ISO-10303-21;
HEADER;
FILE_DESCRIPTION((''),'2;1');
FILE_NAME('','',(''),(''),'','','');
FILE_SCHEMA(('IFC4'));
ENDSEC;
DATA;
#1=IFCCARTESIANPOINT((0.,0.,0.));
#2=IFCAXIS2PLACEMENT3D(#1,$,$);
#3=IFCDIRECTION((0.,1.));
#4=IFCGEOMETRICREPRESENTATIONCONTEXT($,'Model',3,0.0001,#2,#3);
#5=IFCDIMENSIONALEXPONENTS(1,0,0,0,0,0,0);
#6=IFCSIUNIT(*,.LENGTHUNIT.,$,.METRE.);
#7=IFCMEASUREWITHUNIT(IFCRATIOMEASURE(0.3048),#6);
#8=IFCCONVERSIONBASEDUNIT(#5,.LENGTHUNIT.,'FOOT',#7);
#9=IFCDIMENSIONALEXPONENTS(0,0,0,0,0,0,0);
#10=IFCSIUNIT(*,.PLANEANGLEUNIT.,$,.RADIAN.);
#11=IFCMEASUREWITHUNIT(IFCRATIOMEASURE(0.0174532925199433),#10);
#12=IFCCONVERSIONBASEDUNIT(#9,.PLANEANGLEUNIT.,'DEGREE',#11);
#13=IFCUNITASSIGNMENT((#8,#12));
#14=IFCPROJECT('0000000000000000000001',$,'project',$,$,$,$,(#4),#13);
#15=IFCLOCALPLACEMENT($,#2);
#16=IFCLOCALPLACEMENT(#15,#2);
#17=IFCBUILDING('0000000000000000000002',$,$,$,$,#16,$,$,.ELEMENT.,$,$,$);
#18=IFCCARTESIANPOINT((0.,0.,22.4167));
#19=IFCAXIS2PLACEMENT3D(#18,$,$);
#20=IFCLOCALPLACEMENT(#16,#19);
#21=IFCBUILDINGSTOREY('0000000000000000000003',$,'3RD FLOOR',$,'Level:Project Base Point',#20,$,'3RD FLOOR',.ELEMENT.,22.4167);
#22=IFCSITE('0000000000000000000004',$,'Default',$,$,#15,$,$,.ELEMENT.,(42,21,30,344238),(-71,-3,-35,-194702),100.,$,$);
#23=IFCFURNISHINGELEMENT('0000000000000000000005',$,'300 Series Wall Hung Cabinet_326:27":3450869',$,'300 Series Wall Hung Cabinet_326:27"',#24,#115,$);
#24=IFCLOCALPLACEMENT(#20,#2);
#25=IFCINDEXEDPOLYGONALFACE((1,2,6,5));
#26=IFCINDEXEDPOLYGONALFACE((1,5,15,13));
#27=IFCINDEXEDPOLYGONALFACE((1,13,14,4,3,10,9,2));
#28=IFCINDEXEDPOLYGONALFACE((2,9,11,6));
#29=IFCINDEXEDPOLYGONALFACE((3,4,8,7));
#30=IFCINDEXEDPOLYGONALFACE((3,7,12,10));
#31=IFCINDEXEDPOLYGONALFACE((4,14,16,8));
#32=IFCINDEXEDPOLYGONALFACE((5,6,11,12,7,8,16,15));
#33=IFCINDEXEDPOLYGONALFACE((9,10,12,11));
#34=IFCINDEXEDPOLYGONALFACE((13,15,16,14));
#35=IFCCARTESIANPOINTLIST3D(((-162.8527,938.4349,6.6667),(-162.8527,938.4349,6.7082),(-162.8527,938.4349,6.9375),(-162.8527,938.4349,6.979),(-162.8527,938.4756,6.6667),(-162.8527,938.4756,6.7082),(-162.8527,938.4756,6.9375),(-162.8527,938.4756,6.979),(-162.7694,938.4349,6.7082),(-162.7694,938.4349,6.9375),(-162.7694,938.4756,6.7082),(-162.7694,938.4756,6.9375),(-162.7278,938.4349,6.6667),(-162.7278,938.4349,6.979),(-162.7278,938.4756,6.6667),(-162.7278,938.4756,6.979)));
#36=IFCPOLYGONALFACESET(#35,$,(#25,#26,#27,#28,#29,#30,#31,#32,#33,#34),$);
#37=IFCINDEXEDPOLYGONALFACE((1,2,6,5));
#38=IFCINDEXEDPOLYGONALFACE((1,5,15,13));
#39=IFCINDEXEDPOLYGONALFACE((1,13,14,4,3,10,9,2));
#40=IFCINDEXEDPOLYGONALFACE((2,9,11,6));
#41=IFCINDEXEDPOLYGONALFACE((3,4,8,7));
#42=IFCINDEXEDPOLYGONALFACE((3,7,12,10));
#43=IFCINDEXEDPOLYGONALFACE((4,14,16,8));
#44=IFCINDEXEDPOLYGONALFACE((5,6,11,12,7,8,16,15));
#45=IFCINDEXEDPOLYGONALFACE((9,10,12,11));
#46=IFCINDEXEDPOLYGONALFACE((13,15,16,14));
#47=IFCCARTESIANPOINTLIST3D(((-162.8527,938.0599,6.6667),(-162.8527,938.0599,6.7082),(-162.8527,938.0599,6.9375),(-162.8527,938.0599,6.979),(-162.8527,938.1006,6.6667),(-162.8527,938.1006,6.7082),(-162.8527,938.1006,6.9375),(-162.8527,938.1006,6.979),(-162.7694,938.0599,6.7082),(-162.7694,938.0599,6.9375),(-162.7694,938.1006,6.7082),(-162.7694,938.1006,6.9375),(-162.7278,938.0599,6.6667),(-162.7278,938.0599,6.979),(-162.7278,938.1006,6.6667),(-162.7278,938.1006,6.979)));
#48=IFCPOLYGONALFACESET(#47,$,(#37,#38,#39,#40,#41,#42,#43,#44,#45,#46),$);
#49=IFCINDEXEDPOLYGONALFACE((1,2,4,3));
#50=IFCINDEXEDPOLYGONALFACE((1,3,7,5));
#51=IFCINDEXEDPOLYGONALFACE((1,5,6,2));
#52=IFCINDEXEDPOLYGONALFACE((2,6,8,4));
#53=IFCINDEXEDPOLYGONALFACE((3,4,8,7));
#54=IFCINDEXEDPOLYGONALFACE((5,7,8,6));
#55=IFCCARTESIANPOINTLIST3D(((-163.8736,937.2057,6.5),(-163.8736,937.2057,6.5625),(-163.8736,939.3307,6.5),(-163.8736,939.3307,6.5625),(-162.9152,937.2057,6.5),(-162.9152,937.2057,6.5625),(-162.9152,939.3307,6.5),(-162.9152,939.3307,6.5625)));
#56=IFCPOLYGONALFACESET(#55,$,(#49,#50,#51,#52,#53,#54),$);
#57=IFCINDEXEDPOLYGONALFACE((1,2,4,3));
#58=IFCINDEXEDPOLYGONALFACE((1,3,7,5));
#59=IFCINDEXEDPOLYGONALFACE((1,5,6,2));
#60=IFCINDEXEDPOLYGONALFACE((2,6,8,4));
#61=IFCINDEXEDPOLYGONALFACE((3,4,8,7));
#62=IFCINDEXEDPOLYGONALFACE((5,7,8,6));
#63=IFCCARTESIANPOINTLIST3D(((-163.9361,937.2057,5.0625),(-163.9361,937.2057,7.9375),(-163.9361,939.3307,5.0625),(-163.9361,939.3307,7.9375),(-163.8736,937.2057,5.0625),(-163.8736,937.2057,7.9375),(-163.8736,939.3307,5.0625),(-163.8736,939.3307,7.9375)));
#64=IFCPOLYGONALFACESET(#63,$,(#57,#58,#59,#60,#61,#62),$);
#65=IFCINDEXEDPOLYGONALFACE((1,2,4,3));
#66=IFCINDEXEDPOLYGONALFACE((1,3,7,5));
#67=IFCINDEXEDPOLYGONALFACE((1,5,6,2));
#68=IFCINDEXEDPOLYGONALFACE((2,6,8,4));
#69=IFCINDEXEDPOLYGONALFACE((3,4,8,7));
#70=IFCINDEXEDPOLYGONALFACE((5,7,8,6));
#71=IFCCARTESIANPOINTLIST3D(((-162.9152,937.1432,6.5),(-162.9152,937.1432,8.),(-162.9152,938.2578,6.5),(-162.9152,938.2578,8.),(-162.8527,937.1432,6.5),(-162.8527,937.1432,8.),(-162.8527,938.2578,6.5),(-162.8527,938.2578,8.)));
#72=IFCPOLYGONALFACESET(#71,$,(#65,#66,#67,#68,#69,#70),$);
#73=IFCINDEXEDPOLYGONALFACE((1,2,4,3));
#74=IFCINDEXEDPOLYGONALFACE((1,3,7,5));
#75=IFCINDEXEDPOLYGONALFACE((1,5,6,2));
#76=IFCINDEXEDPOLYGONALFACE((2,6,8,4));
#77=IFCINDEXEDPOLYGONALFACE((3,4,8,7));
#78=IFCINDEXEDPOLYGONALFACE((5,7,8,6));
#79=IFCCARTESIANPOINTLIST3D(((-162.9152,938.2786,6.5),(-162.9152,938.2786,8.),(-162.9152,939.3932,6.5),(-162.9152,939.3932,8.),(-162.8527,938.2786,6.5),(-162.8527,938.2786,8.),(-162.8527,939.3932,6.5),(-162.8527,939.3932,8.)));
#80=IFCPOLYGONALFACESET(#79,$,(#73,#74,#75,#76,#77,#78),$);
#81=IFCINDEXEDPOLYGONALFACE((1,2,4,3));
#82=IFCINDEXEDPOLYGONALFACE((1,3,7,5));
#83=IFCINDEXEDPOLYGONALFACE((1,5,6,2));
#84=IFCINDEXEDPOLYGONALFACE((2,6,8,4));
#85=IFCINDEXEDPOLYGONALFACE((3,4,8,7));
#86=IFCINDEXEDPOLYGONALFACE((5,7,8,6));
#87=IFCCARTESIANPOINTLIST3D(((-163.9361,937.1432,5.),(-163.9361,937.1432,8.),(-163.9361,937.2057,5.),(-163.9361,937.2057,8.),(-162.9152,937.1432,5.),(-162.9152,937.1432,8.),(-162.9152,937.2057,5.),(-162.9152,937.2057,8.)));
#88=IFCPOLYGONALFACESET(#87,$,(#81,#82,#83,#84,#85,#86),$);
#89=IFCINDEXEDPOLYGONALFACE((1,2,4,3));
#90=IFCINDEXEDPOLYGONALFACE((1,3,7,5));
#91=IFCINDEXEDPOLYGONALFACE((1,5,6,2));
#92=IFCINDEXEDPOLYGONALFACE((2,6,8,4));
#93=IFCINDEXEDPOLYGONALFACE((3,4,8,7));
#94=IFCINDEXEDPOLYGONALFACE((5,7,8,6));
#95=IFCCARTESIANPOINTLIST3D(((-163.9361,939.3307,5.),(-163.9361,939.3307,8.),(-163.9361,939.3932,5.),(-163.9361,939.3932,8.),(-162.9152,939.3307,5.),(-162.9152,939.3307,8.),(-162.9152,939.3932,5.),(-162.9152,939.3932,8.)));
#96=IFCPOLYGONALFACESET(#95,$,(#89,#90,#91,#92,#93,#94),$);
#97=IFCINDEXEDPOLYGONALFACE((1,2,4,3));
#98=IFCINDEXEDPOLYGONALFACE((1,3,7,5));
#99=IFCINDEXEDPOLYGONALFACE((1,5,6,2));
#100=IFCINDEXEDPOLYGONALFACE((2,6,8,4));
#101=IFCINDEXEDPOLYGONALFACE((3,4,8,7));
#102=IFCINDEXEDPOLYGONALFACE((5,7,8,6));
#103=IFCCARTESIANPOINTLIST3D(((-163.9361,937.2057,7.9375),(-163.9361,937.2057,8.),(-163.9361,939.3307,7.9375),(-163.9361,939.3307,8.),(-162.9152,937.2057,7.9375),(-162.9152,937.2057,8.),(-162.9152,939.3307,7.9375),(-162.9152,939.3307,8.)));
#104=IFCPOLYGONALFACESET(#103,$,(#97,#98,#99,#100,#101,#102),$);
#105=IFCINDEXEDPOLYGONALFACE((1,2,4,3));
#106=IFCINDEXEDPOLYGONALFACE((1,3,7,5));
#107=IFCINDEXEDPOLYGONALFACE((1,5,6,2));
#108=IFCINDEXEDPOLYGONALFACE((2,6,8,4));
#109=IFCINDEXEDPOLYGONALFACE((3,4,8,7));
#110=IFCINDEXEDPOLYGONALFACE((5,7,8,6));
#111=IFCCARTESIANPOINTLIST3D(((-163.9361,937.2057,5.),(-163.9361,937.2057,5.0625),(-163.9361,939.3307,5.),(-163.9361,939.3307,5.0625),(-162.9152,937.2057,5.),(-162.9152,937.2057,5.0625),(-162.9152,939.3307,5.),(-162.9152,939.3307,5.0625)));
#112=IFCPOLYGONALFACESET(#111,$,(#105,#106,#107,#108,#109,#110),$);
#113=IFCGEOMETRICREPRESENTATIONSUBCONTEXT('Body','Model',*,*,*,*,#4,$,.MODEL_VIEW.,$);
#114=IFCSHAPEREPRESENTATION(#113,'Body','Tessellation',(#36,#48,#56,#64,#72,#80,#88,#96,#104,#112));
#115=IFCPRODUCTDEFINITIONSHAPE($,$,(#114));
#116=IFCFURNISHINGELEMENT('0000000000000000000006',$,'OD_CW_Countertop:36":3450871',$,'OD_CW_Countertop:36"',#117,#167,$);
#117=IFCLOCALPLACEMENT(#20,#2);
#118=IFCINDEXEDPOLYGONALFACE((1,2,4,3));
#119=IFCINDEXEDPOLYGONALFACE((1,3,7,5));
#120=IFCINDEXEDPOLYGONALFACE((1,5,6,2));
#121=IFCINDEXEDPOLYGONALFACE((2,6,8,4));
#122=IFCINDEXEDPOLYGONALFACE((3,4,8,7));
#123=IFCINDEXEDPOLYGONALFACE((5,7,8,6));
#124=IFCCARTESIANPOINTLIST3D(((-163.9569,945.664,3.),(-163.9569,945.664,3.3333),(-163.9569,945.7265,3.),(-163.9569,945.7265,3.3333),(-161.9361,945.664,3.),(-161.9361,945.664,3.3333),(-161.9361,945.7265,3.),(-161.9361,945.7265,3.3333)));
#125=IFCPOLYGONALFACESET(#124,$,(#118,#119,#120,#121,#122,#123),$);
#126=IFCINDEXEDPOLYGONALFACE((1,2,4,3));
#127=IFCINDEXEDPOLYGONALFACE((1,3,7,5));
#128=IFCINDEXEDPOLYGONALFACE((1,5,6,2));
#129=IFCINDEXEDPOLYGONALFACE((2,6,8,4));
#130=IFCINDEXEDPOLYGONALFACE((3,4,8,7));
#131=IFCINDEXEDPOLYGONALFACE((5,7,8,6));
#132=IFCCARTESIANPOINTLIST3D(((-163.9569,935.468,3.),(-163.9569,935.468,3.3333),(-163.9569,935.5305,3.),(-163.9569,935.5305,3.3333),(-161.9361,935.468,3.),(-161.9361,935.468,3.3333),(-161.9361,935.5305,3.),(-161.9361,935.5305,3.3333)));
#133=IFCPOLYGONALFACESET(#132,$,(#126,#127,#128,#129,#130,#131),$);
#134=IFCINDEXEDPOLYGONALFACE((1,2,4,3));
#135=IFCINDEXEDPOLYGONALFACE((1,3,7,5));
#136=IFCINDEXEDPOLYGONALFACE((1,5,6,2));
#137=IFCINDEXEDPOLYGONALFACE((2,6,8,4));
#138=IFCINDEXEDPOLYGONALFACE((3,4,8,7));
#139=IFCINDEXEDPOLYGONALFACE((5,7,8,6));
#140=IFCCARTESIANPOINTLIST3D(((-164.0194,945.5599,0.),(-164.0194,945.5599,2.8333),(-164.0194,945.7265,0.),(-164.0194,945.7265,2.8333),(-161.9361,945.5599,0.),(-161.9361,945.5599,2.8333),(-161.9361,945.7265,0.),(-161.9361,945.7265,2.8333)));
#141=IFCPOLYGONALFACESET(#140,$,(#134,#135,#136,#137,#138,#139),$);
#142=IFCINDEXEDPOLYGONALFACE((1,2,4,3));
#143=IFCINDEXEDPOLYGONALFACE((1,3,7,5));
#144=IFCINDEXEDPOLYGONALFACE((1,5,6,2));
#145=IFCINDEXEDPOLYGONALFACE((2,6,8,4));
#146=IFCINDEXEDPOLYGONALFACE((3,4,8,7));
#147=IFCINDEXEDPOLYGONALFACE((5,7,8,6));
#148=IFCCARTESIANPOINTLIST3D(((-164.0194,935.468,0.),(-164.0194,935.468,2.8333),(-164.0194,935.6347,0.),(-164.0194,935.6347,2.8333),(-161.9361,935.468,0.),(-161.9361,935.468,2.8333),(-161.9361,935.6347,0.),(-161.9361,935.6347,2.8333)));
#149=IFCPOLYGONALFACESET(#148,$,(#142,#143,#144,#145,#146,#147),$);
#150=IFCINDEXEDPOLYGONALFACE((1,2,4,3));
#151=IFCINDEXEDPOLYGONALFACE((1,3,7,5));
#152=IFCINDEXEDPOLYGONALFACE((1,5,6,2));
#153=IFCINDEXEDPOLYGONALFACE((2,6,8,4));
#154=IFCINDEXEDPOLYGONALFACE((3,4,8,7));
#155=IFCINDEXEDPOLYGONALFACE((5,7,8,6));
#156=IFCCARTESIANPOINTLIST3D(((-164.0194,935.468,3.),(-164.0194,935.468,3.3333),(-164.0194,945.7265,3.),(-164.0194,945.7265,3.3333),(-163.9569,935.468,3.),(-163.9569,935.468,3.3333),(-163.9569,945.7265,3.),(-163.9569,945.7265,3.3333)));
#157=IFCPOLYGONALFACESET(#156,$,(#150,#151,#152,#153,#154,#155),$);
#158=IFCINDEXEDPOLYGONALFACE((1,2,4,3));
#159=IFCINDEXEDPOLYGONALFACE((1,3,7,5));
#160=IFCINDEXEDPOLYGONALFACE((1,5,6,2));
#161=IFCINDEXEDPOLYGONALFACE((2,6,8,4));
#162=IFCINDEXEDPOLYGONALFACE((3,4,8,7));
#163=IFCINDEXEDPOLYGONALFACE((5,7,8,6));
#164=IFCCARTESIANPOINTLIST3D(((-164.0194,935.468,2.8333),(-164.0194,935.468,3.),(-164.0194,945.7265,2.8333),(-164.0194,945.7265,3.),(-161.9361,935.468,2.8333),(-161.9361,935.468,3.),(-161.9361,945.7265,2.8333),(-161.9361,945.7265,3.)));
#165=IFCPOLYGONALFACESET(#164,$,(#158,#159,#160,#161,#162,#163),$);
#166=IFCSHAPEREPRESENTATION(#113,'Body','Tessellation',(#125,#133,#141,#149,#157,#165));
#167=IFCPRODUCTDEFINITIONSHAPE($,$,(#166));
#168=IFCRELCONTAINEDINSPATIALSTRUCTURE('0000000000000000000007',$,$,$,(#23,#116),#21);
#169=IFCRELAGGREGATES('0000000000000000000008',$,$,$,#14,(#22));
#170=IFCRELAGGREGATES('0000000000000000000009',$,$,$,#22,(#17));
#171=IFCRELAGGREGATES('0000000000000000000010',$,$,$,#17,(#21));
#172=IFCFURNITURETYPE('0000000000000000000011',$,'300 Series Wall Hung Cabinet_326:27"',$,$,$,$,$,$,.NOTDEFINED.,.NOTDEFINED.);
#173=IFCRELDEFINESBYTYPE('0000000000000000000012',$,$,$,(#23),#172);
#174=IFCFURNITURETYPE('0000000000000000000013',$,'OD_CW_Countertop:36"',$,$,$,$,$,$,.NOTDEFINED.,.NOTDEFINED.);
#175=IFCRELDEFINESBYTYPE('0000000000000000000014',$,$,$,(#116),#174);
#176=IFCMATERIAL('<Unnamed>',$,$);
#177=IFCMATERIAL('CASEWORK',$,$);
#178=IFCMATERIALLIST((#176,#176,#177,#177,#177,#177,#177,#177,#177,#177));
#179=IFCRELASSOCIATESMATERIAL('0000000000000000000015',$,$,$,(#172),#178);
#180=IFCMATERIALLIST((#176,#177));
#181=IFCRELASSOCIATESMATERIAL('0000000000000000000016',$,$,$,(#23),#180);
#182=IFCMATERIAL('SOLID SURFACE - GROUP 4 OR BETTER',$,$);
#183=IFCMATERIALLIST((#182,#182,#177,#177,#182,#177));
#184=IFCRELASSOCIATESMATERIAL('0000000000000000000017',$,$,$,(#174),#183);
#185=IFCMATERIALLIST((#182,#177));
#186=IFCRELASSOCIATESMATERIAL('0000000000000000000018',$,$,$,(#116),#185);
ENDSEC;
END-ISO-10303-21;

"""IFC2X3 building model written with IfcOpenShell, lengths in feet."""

from ifc_helpers import new_model, entity, si_unit, converted_unit, direction, frame, frame_2d, origin, origin_2d_with_axis, place, context, subcontext, project, spatial, polyline, rectangle, outline, extrude, source, transform, mapped, material, material_list, type_object, type_shapes, element, save


model = new_model("IFC2X3")

# Units and contexts
model_context = context("Model", 3, precision=0.0001, world=origin(), true_north=direction((0.0, 1.0)))
body_context = subcontext(model_context, "Body", "Model", "MODEL_VIEW")
ifc_project = project(units=[converted_unit("LENGTHUNIT", "FOOT", entity("IfcRatioMeasure", 0.3048), si_unit("LENGTHUNIT", "METRE"), dimensions=[1, 0, 0, 0, 0, 0, 0]), converted_unit("PLANEANGLEUNIT", "DEGREE", entity("IfcRatioMeasure", 0.0174532925199433), si_unit("PLANEANGLEUNIT", "RADIAN"), dimensions=[0, 0, 0, 0, 0, 0, 0])], contexts=[model_context])

# Site, building, storey
site_placement = place(None, origin())
site = spatial("IfcSite", under=ifc_project, at=site_placement, Name="Default", CompositionType="ELEMENT", RefLatitude=(42, 21, 30, 344238), RefLongitude=(-71, -3, -35, -194702), RefElevation=100.0)
building_placement = place(site_placement, origin())
building = spatial("IfcBuilding", under=site, at=building_placement, CompositionType="ELEMENT")
storey_placement = place(building_placement, frame((0.0, 0.0, 22.4167)))
storey = spatial("IfcBuildingStorey", under=building, at=storey_placement, Name="3RD FLOOR", ObjectType="Level:Project Base Point", LongName="3RD FLOOR", CompositionType="ELEMENT", Elevation=22.4167)

# Furnishing elements
ifc_material_1 = material(Name="CASEWORK")
ifc_material_2 = material(Name="<Unnamed>")
ifc_material_list_1 = material_list([ifc_material_2, ifc_material_1])
ifc_material_list_2 = material_list([ifc_material_2, ifc_material_2, ifc_material_1, ifc_material_1, ifc_material_1, ifc_material_1, ifc_material_1, ifc_material_1, ifc_material_1, ifc_material_1])
furniture_type_1 = type_object("IfcFurnitureType", Name="300 Series Wall Hung Cabinet_326:27\"", material=ifc_material_list_2)
shared_shape_1 = source(origin(), body_context, "Body", "SweptSolid", [
    extrude(outline(polyline([(0.1146, -0.0521), (0.1562, -0.0521), (0.1562, 0.0729), (-0.1562, 0.0729), (-0.1562, -0.0521), (-0.1146, -0.0521), (-0.1146, 0.0313), (0.1146, 0.0313), (0.1146, -0.0521)])), frame((1.2917, 0.0729, 1.8229), z_axis=(1.0, 0.0, 0.0), x_axis=(0.0, 0.0, 1.0)), (0.0, 0.0, 1.0), 0.0407),
    extrude(outline(polyline([(0.1146, -0.0521), (0.1562, -0.0521), (0.1562, 0.0729), (-0.1562, 0.0729), (-0.1562, -0.0521), (-0.1146, -0.0521), (-0.1146, 0.0313), (0.1146, 0.0313), (0.1146, -0.0521)])), frame((0.9167, 0.0729, 1.8229), z_axis=(1.0, 0.0, 0.0), x_axis=(0.0, 0.0, 1.0)), (0.0, 0.0, 1.0), 0.0407),
    extrude(rectangle(XDim=0.9583, YDim=2.125, at=origin_2d_with_axis()), frame((1.125, 0.6666, 1.5), z_axis=(0.0, 0.0, 1.0), x_axis=(0.0, 1.0, 0.0)), (0.0, 0.0, 1.0), 0.0625),
    extrude(rectangle(XDim=2.125, YDim=0.0625, at=origin_2d_with_axis()), frame((1.125, 1.177, 0.0625), z_axis=(0.0, 0.0, 1.0), x_axis=(-1.0, 0.0, 0.0)), (0.0, 0.0, 1.0), 2.875),
    extrude(rectangle(XDim=1.1146, YDim=0.0625, at=frame_2d((0.0, 0.0), x_axis=(1.0, 0.0))), frame((0.5573, 0.1562, 1.5), z_axis=(0.0, 0.0, 1.0), x_axis=(-1.0, 0.0, 0.0)), (0.0, 0.0, 1.0), 1.5),
    extrude(rectangle(XDim=1.1146, YDim=0.0625, at=frame_2d((0.0, 0.0), x_axis=(1.0, 0.0))), frame((1.6927, 0.1562, 1.5), z_axis=(0.0, 0.0, 1.0), x_axis=(-1.0, 0.0, 0.0)), (0.0, 0.0, 1.0), 1.5),
    extrude(rectangle(XDim=1.0208, YDim=0.0625, at=frame_2d((0.0, 0.0), x_axis=(1.0, 0.0))), frame((0.0313, 0.6979, 0.0), z_axis=(0.0, 0.0, 1.0), x_axis=(0.0, -1.0, 0.0)), (0.0, 0.0, 1.0), 3.0),
    extrude(rectangle(XDim=1.0208, YDim=0.0625, at=frame_2d((0.0, 0.0), x_axis=(1.0, 0.0))), frame((2.2188, 0.6979, 0.0), z_axis=(0.0, 0.0, 1.0), x_axis=(0.0, -1.0, 0.0)), (0.0, 0.0, 1.0), 3.0),
    extrude(rectangle(XDim=1.0208, YDim=2.125, at=origin_2d_with_axis()), frame((1.125, 0.6979, 2.9375), z_axis=(0.0, 0.0, 1.0), x_axis=(0.0, 1.0, 0.0)), (0.0, 0.0, 1.0), 0.0625),
    extrude(rectangle(XDim=1.0208, YDim=2.125, at=origin_2d_with_axis()), frame((1.125, 0.6979, 0.0), z_axis=(0.0, 0.0, 1.0), x_axis=(0.0, 1.0, 0.0)), (0.0, 0.0, 1.0), 0.0625),
])
type_shapes(furniture_type_1, [shared_shape_1])
furnishing_1_placement = place(storey_placement, frame((-162.7278, 937.1432, 5.0), z_axis=(0.0, 0.0, 1.0), x_axis=(0.0, 1.0, 0.0)))
element("IfcFurnishingElement", 1, at=furnishing_1_placement, inside=storey, type_object=furniture_type_1, material=ifc_material_list_1, Name="300 Series Wall Hung Cabinet_326:27\":3450869", ObjectType="300 Series Wall Hung Cabinet_326:27\"", context=body_context, shape_type="MappedRepresentation", body=[
    mapped(shared_shape_1, transform((0.0, 0.0, 0.0), scale=1.0)),
])
ifc_material_3 = material(Name="SOLID SURFACE - GROUP 4 OR BETTER")
ifc_material_list_3 = material_list([ifc_material_3, ifc_material_1])
ifc_material_list_4 = material_list([ifc_material_3, ifc_material_3, ifc_material_1, ifc_material_1, ifc_material_3, ifc_material_1])
furniture_type_2 = type_object("IfcFurnitureType", Name="OD_CW_Countertop:36\"", material=ifc_material_list_4)
shared_shape_2 = source(origin(), body_context, "Body", "SweptSolid", [
    extrude(rectangle(XDim=0.0625, YDim=2.0208, at=origin_2d_with_axis()), frame((10.2272, 1.0104, 3.0), z_axis=(0.0, 0.0, 1.0), x_axis=(-1.0, 0.0, 0.0)), (0.0, 0.0, 1.0), 0.3333),
    extrude(rectangle(XDim=0.0625, YDim=2.0208, at=origin_2d_with_axis()), frame((0.0313, 1.0104, 3.0), z_axis=(0.0, 0.0, 1.0), x_axis=(-1.0, 0.0, 0.0)), (0.0, 0.0, 1.0), 0.3333),
    extrude(rectangle(XDim=2.0833, YDim=0.1667, at=frame_2d((0.0, 0.0), x_axis=(1.0, 0.0))), frame((10.1751, 1.0417, 0.0), z_axis=(0.0, 0.0, 1.0), x_axis=(0.0, -1.0, 0.0)), (0.0, 0.0, 1.0), 2.8333),
    extrude(rectangle(XDim=2.0833, YDim=0.1667, at=origin_2d_with_axis()), frame((0.0833, 1.0417, 0.0), z_axis=(0.0, 0.0, 1.0), x_axis=(0.0, -1.0, 0.0)), (0.0, 0.0, 1.0), 2.8333),
    extrude(rectangle(XDim=0.0625, YDim=10.2585, at=frame_2d((0.0, 0.0), x_axis=(1.0, 0.0))), frame((5.1292, 2.0521, 3.0), z_axis=(0.0, 0.0, 1.0), x_axis=(0.0, -1.0, 0.0)), (0.0, 0.0, 1.0), 0.3333),
    extrude(rectangle(XDim=2.0833, YDim=10.2585, at=origin_2d_with_axis()), frame((5.1292, 1.0417, 2.8333), z_axis=(0.0, 0.0, 1.0), x_axis=(0.0, -1.0, 0.0)), (0.0, 0.0, 1.0), 0.1667),
])
type_shapes(furniture_type_2, [shared_shape_2])
furnishing_2_placement = place(storey_placement, frame((-161.9361, 935.468, 0.0), z_axis=(0.0, 0.0, 1.0), x_axis=(0.0, 1.0, 0.0)))
element("IfcFurnishingElement", 2, at=furnishing_2_placement, inside=storey, type_object=furniture_type_2, material=ifc_material_list_3, Name="OD_CW_Countertop:36\":3450871", ObjectType="OD_CW_Countertop:36\"", context=body_context, shape_type="MappedRepresentation", body=[
    mapped(shared_shape_2, transform((0.0, 0.0, 0.0), scale=1.0)),
])

save(model, "model.ifc")
